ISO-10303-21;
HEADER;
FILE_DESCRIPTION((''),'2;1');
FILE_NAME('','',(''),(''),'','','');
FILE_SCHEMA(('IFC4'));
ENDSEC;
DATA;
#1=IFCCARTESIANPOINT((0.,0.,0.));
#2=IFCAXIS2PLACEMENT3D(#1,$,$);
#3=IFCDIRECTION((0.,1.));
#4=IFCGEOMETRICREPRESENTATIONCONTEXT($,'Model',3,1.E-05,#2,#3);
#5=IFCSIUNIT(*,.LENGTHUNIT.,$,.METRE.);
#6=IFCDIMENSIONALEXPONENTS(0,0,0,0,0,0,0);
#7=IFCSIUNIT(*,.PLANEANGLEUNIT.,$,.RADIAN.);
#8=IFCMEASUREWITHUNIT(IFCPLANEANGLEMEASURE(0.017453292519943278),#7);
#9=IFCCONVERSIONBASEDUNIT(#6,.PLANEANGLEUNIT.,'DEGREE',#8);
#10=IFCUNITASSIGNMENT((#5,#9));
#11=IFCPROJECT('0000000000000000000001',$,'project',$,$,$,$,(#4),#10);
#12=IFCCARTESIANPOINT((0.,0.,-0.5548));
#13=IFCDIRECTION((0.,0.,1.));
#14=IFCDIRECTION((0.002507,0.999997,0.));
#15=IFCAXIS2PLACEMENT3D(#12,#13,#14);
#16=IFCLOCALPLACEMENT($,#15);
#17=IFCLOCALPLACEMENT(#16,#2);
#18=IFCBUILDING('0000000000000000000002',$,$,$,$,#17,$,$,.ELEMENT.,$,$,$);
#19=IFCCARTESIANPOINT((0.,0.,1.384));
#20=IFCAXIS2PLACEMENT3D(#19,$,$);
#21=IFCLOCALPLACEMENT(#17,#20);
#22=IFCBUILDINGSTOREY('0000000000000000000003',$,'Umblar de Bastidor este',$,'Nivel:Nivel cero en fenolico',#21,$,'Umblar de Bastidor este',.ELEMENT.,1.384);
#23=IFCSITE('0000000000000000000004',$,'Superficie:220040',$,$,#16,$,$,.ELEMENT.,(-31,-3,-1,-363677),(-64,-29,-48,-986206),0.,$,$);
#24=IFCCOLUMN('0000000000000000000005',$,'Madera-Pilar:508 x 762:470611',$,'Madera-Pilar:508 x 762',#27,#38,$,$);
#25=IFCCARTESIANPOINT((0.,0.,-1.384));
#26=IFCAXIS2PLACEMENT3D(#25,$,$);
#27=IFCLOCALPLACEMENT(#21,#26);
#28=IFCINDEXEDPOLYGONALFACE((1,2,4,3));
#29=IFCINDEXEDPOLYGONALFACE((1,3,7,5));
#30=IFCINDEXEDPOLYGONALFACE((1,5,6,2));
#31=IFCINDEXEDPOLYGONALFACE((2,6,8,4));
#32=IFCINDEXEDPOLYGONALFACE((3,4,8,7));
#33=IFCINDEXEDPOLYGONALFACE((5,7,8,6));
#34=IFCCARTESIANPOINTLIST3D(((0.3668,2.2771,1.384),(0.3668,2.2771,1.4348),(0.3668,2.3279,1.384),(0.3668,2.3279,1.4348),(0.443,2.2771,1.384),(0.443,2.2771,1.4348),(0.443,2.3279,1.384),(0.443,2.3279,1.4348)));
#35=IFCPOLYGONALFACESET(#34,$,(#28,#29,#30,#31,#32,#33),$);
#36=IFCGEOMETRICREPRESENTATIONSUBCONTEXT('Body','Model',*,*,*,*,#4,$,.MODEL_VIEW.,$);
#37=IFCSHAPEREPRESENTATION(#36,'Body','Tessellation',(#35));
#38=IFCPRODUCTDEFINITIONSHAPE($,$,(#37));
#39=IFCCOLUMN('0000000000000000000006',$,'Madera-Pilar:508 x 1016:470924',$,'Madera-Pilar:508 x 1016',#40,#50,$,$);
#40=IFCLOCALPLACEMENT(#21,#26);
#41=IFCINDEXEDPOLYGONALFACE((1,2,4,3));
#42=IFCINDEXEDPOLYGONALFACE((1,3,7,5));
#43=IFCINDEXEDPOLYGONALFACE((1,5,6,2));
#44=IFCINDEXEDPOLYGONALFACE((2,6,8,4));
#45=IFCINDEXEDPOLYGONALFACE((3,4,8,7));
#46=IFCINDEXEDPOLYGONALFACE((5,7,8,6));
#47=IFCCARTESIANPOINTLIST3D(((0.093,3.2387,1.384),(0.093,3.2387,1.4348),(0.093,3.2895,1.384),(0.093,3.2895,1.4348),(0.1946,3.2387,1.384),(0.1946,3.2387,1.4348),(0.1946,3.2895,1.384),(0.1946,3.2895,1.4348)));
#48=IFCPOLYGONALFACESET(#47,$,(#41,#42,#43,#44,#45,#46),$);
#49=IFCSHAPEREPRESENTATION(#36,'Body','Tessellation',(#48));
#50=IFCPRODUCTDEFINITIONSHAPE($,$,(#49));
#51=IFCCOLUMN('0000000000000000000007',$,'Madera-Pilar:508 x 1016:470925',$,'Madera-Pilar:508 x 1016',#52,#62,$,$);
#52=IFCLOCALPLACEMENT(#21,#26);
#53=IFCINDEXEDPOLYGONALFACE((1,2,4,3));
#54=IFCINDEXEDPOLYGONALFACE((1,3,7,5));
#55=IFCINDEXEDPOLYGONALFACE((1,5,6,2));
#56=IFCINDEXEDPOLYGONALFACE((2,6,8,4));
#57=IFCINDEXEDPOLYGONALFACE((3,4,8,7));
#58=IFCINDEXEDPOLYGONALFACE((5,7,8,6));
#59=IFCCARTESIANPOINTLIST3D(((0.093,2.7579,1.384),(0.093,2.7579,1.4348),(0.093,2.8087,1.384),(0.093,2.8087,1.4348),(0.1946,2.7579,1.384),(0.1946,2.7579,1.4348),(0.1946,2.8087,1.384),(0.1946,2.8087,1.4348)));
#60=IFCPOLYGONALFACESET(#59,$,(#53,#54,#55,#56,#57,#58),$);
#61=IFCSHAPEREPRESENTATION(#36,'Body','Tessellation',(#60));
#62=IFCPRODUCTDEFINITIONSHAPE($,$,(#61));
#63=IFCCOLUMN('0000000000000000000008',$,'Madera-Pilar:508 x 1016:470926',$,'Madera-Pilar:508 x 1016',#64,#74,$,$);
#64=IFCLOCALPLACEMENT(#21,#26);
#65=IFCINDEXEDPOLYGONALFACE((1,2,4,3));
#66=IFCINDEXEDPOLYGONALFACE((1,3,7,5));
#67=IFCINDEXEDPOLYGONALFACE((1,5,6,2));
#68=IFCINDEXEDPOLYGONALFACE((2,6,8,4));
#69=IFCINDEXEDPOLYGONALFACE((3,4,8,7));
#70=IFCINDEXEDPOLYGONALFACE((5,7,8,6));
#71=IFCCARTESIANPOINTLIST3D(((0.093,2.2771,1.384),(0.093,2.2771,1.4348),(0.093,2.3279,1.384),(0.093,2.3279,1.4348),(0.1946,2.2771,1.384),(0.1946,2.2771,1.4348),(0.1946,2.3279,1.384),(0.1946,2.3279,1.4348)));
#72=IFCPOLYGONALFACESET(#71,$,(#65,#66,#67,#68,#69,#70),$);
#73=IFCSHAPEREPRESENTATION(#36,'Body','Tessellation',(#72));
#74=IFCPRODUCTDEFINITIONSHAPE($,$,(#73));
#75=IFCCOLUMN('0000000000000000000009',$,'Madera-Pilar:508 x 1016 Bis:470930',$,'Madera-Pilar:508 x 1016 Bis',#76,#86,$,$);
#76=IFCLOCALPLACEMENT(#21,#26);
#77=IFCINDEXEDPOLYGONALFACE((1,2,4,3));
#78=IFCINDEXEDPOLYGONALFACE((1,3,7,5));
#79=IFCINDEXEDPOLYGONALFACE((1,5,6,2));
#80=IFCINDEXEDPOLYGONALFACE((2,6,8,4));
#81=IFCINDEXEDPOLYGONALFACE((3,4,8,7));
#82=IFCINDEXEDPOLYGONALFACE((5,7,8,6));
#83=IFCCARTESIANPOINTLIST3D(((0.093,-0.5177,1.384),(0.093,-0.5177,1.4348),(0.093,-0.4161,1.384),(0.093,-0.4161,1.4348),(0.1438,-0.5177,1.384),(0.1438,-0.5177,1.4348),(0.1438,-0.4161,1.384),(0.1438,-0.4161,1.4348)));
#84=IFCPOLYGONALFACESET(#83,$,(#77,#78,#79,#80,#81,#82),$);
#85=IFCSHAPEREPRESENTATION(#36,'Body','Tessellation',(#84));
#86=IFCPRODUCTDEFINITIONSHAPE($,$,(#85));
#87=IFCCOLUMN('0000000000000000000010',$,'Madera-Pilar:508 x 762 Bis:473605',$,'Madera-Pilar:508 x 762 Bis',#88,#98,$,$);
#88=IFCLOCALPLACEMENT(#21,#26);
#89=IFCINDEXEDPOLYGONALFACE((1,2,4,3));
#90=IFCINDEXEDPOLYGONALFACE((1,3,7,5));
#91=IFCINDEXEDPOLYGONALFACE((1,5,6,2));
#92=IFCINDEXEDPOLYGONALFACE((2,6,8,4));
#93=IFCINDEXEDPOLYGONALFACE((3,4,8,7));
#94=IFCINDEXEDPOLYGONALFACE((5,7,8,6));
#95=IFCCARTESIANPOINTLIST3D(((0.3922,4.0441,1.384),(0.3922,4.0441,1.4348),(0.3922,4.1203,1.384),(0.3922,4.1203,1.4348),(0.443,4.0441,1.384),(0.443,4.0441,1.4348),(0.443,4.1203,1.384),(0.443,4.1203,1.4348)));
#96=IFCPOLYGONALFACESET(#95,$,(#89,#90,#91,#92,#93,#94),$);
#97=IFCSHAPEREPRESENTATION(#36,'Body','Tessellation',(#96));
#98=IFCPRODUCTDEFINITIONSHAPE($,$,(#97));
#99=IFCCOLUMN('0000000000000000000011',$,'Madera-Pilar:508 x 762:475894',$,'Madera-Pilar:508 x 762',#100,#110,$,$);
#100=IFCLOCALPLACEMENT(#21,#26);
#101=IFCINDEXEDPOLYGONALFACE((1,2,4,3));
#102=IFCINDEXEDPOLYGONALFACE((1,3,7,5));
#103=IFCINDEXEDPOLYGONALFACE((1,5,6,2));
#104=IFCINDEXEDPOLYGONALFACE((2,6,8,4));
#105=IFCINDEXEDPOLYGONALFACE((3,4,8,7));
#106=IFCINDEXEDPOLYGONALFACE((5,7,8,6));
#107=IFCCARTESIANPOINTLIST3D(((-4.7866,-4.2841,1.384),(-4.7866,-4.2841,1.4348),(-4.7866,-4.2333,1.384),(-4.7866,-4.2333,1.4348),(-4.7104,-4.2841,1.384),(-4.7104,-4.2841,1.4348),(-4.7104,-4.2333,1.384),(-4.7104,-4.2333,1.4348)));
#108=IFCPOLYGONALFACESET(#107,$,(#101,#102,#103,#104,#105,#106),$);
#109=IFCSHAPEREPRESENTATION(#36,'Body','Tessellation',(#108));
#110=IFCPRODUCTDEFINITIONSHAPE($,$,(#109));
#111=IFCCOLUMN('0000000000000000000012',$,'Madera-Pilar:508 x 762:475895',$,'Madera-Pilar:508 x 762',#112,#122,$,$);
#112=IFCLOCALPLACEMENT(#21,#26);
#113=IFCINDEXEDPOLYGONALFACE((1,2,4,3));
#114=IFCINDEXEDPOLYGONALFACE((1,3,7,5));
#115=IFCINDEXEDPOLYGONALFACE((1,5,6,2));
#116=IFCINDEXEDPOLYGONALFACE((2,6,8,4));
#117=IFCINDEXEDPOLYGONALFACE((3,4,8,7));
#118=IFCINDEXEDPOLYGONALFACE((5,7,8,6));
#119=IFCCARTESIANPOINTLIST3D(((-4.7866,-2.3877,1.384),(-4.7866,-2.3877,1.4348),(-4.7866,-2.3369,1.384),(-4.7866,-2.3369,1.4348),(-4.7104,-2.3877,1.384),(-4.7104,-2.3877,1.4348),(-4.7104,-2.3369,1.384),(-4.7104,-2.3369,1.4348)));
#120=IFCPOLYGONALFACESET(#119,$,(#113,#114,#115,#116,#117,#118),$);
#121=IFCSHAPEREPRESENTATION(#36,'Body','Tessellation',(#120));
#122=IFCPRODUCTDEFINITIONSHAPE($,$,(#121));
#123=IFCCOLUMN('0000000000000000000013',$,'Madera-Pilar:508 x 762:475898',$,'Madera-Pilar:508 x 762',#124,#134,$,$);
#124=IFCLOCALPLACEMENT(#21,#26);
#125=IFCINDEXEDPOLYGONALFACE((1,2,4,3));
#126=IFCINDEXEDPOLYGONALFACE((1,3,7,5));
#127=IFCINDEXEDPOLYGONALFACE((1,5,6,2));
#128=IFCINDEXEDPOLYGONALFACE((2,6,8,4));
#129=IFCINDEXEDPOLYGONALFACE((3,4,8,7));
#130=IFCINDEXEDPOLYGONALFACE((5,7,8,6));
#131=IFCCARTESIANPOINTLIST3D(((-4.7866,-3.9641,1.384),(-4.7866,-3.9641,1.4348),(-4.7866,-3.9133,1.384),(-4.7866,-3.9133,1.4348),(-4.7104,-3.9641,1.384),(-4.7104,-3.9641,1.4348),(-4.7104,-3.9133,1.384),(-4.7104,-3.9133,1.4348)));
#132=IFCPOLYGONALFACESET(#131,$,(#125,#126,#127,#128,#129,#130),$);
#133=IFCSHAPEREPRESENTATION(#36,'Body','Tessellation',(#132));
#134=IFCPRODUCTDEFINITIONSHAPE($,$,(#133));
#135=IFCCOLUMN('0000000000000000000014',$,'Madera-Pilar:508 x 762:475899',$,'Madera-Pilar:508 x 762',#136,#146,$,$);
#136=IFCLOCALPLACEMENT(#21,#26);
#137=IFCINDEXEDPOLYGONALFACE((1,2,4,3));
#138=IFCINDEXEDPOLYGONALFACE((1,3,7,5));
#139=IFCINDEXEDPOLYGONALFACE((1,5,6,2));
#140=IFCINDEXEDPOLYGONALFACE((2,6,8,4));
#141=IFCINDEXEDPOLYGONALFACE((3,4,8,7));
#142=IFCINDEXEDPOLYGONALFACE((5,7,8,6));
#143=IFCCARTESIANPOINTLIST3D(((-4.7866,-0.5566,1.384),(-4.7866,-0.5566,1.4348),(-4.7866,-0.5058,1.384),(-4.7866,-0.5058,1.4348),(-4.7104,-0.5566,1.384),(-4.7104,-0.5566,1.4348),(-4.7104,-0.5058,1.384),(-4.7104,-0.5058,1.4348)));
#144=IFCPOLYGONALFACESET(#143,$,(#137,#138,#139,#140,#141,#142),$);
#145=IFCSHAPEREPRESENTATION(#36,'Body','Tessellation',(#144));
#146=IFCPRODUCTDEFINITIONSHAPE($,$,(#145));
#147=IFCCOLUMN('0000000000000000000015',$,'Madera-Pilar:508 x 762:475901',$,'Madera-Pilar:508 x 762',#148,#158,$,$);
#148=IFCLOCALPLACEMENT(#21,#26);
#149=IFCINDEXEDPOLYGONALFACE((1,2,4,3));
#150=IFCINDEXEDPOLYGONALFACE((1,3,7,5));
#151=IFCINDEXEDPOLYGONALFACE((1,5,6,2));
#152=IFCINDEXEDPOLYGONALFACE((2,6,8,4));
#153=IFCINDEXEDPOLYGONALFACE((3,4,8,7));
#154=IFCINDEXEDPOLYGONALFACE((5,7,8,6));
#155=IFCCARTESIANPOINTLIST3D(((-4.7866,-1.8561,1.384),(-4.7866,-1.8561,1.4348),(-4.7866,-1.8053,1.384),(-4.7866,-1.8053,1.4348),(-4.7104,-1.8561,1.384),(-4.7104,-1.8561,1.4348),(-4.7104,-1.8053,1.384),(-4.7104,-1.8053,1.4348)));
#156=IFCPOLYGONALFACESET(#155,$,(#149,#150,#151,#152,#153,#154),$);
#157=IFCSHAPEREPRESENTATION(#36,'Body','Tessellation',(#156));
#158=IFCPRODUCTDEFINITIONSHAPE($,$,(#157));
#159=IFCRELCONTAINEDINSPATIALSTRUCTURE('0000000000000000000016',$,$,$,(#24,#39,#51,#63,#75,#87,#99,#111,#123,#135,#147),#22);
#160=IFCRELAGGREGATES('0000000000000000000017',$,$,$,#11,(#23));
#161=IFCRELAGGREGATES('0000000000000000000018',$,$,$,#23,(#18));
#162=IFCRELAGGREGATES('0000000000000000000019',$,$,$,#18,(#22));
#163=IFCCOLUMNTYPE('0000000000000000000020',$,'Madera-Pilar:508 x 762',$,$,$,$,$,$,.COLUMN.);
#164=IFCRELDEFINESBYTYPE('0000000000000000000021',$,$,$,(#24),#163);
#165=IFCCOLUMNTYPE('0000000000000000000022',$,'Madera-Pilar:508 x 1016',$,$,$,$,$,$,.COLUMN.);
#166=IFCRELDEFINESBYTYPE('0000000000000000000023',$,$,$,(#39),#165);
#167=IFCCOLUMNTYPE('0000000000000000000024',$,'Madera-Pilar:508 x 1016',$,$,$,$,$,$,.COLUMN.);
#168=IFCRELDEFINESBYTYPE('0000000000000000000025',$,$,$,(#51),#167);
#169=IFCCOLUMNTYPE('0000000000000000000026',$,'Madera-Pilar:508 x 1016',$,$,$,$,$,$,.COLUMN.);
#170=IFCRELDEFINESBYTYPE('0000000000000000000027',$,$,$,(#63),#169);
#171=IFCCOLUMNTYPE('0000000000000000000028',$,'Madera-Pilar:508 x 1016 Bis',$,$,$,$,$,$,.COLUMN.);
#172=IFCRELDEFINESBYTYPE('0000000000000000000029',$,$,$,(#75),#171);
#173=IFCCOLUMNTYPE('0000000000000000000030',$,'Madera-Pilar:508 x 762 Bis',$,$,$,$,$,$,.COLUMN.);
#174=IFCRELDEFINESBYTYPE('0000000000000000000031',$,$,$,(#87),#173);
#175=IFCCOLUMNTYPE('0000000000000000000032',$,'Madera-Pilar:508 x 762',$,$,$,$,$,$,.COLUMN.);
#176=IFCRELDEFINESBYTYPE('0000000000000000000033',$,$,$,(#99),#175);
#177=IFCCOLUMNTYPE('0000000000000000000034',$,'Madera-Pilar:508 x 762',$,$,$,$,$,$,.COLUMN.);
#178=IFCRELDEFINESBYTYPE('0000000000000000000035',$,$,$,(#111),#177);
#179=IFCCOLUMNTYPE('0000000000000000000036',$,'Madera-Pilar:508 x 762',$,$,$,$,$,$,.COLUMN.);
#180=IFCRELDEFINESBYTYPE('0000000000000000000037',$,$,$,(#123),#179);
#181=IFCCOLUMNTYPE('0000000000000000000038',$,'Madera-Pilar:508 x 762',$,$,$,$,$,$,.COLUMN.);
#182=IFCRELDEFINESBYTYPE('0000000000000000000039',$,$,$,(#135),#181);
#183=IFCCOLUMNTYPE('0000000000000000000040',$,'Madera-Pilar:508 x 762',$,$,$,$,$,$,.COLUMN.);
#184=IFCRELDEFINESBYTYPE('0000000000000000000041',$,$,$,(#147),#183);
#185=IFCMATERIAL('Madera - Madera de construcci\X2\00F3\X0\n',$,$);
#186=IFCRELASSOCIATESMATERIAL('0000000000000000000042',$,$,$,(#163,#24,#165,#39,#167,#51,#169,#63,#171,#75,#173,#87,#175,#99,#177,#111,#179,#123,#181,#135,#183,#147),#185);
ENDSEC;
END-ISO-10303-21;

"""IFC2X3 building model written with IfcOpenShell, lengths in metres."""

from ifc_helpers import new_model, entity, si_unit, converted_unit, direction, frame, frame_2d, origin, origin_2d_with_axis, place, context, subcontext, project, spatial, rectangle, extrude, source, transform, mapped, material, type_object, type_shapes, element, save


model = new_model("IFC2X3")

# Units and contexts
model_context = context("Model", 3, precision=1e-05, world=origin(), true_north=direction((0.0, 1.0)))
body_context = subcontext(model_context, "Body", "Model", "MODEL_VIEW")
ifc_project = project(units=[si_unit("LENGTHUNIT", "METRE"), converted_unit("PLANEANGLEUNIT", "DEGREE", entity("IfcPlaneAngleMeasure", 0.017453292519943278), si_unit("PLANEANGLEUNIT", "RADIAN"), dimensions=[0, 0, 0, 0, 0, 0, 0])], contexts=[model_context])

# Site, building, storey
site_placement = place(None, frame((0.0, 0.0, -0.5548), z_axis=(0.0, 0.0, 1.0), x_axis=(0.002507, 0.999997, 0.0)))
site = spatial("IfcSite", under=ifc_project, at=site_placement, Name="Superficie:220040", CompositionType="ELEMENT", RefLatitude=(-31, -3, -1, -363677), RefLongitude=(-64, -29, -48, -986206), RefElevation=0.0)
building_placement = place(site_placement, origin())
building = spatial("IfcBuilding", under=site, at=building_placement, CompositionType="ELEMENT")
storey_placement = place(building_placement, frame((0.0, 0.0, 1.384)))
storey = spatial("IfcBuildingStorey", under=building, at=storey_placement, Name="Umblar de Bastidor este", ObjectType="Nivel:Nivel cero en fenolico", LongName="Umblar de Bastidor este", CompositionType="ELEMENT", Elevation=1.384)

# Columns
ifc_material = material(Name="Madera - Madera de construcción")
column_type_1 = type_object("IfcColumnType", Name="Madera-Pilar:508 x 762", PredefinedType="COLUMN", material=ifc_material)
shared_shape_1 = source(origin(), body_context, "Body", "SweptSolid", [
    extrude(rectangle(XDim=0.0762, YDim=0.0508, at=origin_2d_with_axis()), frame((0.4049, 2.3025, 1.384), z_axis=(0.0, 0.0, 1.0), x_axis=(-1.0, 0.0, 0.0)), (0.0, 0.0, 1.0), 0.0508),
])
type_shapes(column_type_1, [shared_shape_1])
column_1_placement = place(storey_placement, frame((0.0, 0.0, -1.384)))
element("IfcColumn", 1, at=column_1_placement, inside=storey, type_object=column_type_1, material=ifc_material, Name="Madera-Pilar:508 x 762:470611", ObjectType="Madera-Pilar:508 x 762", context=body_context, shape_type="MappedRepresentation", body=[
    mapped(shared_shape_1, transform((0.0, 0.0, 0.0), scale=1.0)),
])
column_type_2 = type_object("IfcColumnType", Name="Madera-Pilar:508 x 1016", PredefinedType="COLUMN", material=ifc_material)
shared_shape_2 = source(origin(), body_context, "Body", "SweptSolid", [
    extrude(rectangle(XDim=0.1016, YDim=0.0508, at=frame_2d((0.0, 0.0), x_axis=(1.0, 0.0))), frame((0.1438, 3.2641, 1.384), z_axis=(0.0, 0.0, 1.0), x_axis=(-1.0, 0.0, 0.0)), (0.0, 0.0, 1.0), 0.0508),
])
type_shapes(column_type_2, [shared_shape_2])
column_2_placement = place(storey_placement, frame((0.0, 0.0, -1.384)))
element("IfcColumn", 2, at=column_2_placement, inside=storey, type_object=column_type_2, material=ifc_material, Name="Madera-Pilar:508 x 1016:470924", ObjectType="Madera-Pilar:508 x 1016", context=body_context, shape_type="MappedRepresentation", body=[
    mapped(shared_shape_2, transform((0.0, 0.0, 0.0), scale=1.0)),
])
column_type_3 = type_object("IfcColumnType", Name="Madera-Pilar:508 x 1016", PredefinedType="COLUMN", material=ifc_material)
shared_shape_3 = source(origin(), body_context, "Body", "SweptSolid", [
    extrude(rectangle(XDim=0.1016, YDim=0.0508, at=frame_2d((0.0, 0.0), x_axis=(1.0, 0.0))), frame((0.1438, 2.7833, 1.384), z_axis=(0.0, 0.0, 1.0), x_axis=(-1.0, 0.0, 0.0)), (0.0, 0.0, 1.0), 0.0508),
])
type_shapes(column_type_3, [shared_shape_3])
column_3_placement = place(storey_placement, frame((0.0, 0.0, -1.384)))
element("IfcColumn", 3, at=column_3_placement, inside=storey, type_object=column_type_3, material=ifc_material, Name="Madera-Pilar:508 x 1016:470925", ObjectType="Madera-Pilar:508 x 1016", context=body_context, shape_type="MappedRepresentation", body=[
    mapped(shared_shape_3, transform((0.0, 0.0, 0.0), scale=1.0)),
])
column_type_4 = type_object("IfcColumnType", Name="Madera-Pilar:508 x 1016", PredefinedType="COLUMN", material=ifc_material)
shared_shape_4 = source(origin(), body_context, "Body", "SweptSolid", [
    extrude(rectangle(XDim=0.1016, YDim=0.0508, at=frame_2d((0.0, 0.0), x_axis=(1.0, 0.0))), frame((0.1438, 2.3025, 1.384), z_axis=(0.0, 0.0, 1.0), x_axis=(-1.0, 0.0, 0.0)), (0.0, 0.0, 1.0), 0.0508),
])
type_shapes(column_type_4, [shared_shape_4])
column_4_placement = place(storey_placement, frame((0.0, 0.0, -1.384)))
element("IfcColumn", 4, at=column_4_placement, inside=storey, type_object=column_type_4, material=ifc_material, Name="Madera-Pilar:508 x 1016:470926", ObjectType="Madera-Pilar:508 x 1016", context=body_context, shape_type="MappedRepresentation", body=[
    mapped(shared_shape_4, transform((0.0, 0.0, 0.0), scale=1.0)),
])
column_type_5 = type_object("IfcColumnType", Name="Madera-Pilar:508 x 1016 Bis", PredefinedType="COLUMN", material=ifc_material)
shared_shape_5 = source(origin(), body_context, "Body", "SweptSolid", [
    extrude(rectangle(XDim=0.0508, YDim=0.1016, at=frame_2d((0.0, 0.0), x_axis=(1.0, 0.0))), frame((0.1184, -0.4669, 1.384), z_axis=(0.0, 0.0, 1.0), x_axis=(-1.0, 0.0, 0.0)), (0.0, 0.0, 1.0), 0.0508),
])
type_shapes(column_type_5, [shared_shape_5])
column_5_placement = place(storey_placement, frame((0.0, 0.0, -1.384)))
element("IfcColumn", 5, at=column_5_placement, inside=storey, type_object=column_type_5, material=ifc_material, Name="Madera-Pilar:508 x 1016 Bis:470930", ObjectType="Madera-Pilar:508 x 1016 Bis", context=body_context, shape_type="MappedRepresentation", body=[
    mapped(shared_shape_5, transform((0.0, 0.0, 0.0), scale=1.0)),
])
column_type_6 = type_object("IfcColumnType", Name="Madera-Pilar:508 x 762 Bis", PredefinedType="COLUMN", material=ifc_material)
shared_shape_6 = source(origin(), body_context, "Body", "SweptSolid", [
    extrude(rectangle(XDim=0.0508, YDim=0.0762, at=frame_2d((0.0, 0.0), x_axis=(1.0, 0.0))), frame((0.4176, 4.0822, 1.384), z_axis=(0.0, 0.0, 1.0), x_axis=(-1.0, 0.0, 0.0)), (0.0, 0.0, 1.0), 0.0508),
])
type_shapes(column_type_6, [shared_shape_6])
column_6_placement = place(storey_placement, frame((0.0, 0.0, -1.384)))
element("IfcColumn", 6, at=column_6_placement, inside=storey, type_object=column_type_6, material=ifc_material, Name="Madera-Pilar:508 x 762 Bis:473605", ObjectType="Madera-Pilar:508 x 762 Bis", context=body_context, shape_type="MappedRepresentation", body=[
    mapped(shared_shape_6, transform((0.0, 0.0, 0.0), scale=1.0)),
])
column_type_7 = type_object("IfcColumnType", Name="Madera-Pilar:508 x 762", PredefinedType="COLUMN", material=ifc_material)
shared_shape_7 = source(origin(), body_context, "Body", "SweptSolid", [
    extrude(rectangle(XDim=0.0762, YDim=0.0508, at=origin_2d_with_axis()), frame((-4.7485, -4.2587, 1.384), z_axis=(0.0, 0.0, 1.0), x_axis=(-1.0, 0.0, 0.0)), (0.0, 0.0, 1.0), 0.0508),
])
type_shapes(column_type_7, [shared_shape_7])
column_7_placement = place(storey_placement, frame((0.0, 0.0, -1.384)))
element("IfcColumn", 7, at=column_7_placement, inside=storey, type_object=column_type_7, material=ifc_material, Name="Madera-Pilar:508 x 762:475894", ObjectType="Madera-Pilar:508 x 762", context=body_context, shape_type="MappedRepresentation", body=[
    mapped(shared_shape_7, transform((0.0, 0.0, 0.0), scale=1.0)),
])
column_type_8 = type_object("IfcColumnType", Name="Madera-Pilar:508 x 762", PredefinedType="COLUMN", material=ifc_material)
shared_shape_8 = source(origin(), body_context, "Body", "SweptSolid", [
    extrude(rectangle(XDim=0.0762, YDim=0.0508, at=frame_2d((0.0, 0.0), x_axis=(1.0, 0.0))), frame((-4.7485, -2.3623, 1.384), z_axis=(0.0, 0.0, 1.0), x_axis=(-1.0, 0.0, 0.0)), (0.0, 0.0, 1.0), 0.0508),
])
type_shapes(column_type_8, [shared_shape_8])
column_8_placement = place(storey_placement, frame((0.0, 0.0, -1.384)))
element("IfcColumn", 8, at=column_8_placement, inside=storey, type_object=column_type_8, material=ifc_material, Name="Madera-Pilar:508 x 762:475895", ObjectType="Madera-Pilar:508 x 762", context=body_context, shape_type="MappedRepresentation", body=[
    mapped(shared_shape_8, transform((0.0, 0.0, 0.0), scale=1.0)),
])
column_type_9 = type_object("IfcColumnType", Name="Madera-Pilar:508 x 762", PredefinedType="COLUMN", material=ifc_material)
shared_shape_9 = source(origin(), body_context, "Body", "SweptSolid", [
    extrude(rectangle(XDim=0.0762, YDim=0.0508, at=origin_2d_with_axis()), frame((-4.7485, -3.9387, 1.384), z_axis=(0.0, 0.0, 1.0), x_axis=(-1.0, 0.0, 0.0)), (0.0, 0.0, 1.0), 0.0508),
])
type_shapes(column_type_9, [shared_shape_9])
column_9_placement = place(storey_placement, frame((0.0, 0.0, -1.384)))
element("IfcColumn", 9, at=column_9_placement, inside=storey, type_object=column_type_9, material=ifc_material, Name="Madera-Pilar:508 x 762:475898", ObjectType="Madera-Pilar:508 x 762", context=body_context, shape_type="MappedRepresentation", body=[
    mapped(shared_shape_9, transform((0.0, 0.0, 0.0), scale=1.0)),
])
column_type_10 = type_object("IfcColumnType", Name="Madera-Pilar:508 x 762", PredefinedType="COLUMN", material=ifc_material)
shared_shape_10 = source(origin(), body_context, "Body", "SweptSolid", [
    extrude(rectangle(XDim=0.0762, YDim=0.0508, at=frame_2d((0.0, 0.0), x_axis=(1.0, 0.0))), frame((-4.7485, -0.5312, 1.384), z_axis=(0.0, 0.0, 1.0), x_axis=(-1.0, 0.0, 0.0)), (0.0, 0.0, 1.0), 0.0508),
])
type_shapes(column_type_10, [shared_shape_10])
column_10_placement = place(storey_placement, frame((0.0, 0.0, -1.384)))
element("IfcColumn", 10, at=column_10_placement, inside=storey, type_object=column_type_10, material=ifc_material, Name="Madera-Pilar:508 x 762:475899", ObjectType="Madera-Pilar:508 x 762", context=body_context, shape_type="MappedRepresentation", body=[
    mapped(shared_shape_10, transform((0.0, 0.0, 0.0), scale=1.0)),
])
column_type_11 = type_object("IfcColumnType", Name="Madera-Pilar:508 x 762", PredefinedType="COLUMN", material=ifc_material)
shared_shape_11 = source(origin(), body_context, "Body", "SweptSolid", [
    extrude(rectangle(XDim=0.0762, YDim=0.0508, at=origin_2d_with_axis()), frame((-4.7485, -1.8307, 1.384), z_axis=(0.0, 0.0, 1.0), x_axis=(-1.0, 0.0, 0.0)), (0.0, 0.0, 1.0), 0.0508),
])
type_shapes(column_type_11, [shared_shape_11])
column_11_placement = place(storey_placement, frame((0.0, 0.0, -1.384)))
element("IfcColumn", 11, at=column_11_placement, inside=storey, type_object=column_type_11, material=ifc_material, Name="Madera-Pilar:508 x 762:475901", ObjectType="Madera-Pilar:508 x 762", context=body_context, shape_type="MappedRepresentation", body=[
    mapped(shared_shape_11, transform((0.0, 0.0, 0.0), scale=1.0)),
])

save(model, "model.ifc")
